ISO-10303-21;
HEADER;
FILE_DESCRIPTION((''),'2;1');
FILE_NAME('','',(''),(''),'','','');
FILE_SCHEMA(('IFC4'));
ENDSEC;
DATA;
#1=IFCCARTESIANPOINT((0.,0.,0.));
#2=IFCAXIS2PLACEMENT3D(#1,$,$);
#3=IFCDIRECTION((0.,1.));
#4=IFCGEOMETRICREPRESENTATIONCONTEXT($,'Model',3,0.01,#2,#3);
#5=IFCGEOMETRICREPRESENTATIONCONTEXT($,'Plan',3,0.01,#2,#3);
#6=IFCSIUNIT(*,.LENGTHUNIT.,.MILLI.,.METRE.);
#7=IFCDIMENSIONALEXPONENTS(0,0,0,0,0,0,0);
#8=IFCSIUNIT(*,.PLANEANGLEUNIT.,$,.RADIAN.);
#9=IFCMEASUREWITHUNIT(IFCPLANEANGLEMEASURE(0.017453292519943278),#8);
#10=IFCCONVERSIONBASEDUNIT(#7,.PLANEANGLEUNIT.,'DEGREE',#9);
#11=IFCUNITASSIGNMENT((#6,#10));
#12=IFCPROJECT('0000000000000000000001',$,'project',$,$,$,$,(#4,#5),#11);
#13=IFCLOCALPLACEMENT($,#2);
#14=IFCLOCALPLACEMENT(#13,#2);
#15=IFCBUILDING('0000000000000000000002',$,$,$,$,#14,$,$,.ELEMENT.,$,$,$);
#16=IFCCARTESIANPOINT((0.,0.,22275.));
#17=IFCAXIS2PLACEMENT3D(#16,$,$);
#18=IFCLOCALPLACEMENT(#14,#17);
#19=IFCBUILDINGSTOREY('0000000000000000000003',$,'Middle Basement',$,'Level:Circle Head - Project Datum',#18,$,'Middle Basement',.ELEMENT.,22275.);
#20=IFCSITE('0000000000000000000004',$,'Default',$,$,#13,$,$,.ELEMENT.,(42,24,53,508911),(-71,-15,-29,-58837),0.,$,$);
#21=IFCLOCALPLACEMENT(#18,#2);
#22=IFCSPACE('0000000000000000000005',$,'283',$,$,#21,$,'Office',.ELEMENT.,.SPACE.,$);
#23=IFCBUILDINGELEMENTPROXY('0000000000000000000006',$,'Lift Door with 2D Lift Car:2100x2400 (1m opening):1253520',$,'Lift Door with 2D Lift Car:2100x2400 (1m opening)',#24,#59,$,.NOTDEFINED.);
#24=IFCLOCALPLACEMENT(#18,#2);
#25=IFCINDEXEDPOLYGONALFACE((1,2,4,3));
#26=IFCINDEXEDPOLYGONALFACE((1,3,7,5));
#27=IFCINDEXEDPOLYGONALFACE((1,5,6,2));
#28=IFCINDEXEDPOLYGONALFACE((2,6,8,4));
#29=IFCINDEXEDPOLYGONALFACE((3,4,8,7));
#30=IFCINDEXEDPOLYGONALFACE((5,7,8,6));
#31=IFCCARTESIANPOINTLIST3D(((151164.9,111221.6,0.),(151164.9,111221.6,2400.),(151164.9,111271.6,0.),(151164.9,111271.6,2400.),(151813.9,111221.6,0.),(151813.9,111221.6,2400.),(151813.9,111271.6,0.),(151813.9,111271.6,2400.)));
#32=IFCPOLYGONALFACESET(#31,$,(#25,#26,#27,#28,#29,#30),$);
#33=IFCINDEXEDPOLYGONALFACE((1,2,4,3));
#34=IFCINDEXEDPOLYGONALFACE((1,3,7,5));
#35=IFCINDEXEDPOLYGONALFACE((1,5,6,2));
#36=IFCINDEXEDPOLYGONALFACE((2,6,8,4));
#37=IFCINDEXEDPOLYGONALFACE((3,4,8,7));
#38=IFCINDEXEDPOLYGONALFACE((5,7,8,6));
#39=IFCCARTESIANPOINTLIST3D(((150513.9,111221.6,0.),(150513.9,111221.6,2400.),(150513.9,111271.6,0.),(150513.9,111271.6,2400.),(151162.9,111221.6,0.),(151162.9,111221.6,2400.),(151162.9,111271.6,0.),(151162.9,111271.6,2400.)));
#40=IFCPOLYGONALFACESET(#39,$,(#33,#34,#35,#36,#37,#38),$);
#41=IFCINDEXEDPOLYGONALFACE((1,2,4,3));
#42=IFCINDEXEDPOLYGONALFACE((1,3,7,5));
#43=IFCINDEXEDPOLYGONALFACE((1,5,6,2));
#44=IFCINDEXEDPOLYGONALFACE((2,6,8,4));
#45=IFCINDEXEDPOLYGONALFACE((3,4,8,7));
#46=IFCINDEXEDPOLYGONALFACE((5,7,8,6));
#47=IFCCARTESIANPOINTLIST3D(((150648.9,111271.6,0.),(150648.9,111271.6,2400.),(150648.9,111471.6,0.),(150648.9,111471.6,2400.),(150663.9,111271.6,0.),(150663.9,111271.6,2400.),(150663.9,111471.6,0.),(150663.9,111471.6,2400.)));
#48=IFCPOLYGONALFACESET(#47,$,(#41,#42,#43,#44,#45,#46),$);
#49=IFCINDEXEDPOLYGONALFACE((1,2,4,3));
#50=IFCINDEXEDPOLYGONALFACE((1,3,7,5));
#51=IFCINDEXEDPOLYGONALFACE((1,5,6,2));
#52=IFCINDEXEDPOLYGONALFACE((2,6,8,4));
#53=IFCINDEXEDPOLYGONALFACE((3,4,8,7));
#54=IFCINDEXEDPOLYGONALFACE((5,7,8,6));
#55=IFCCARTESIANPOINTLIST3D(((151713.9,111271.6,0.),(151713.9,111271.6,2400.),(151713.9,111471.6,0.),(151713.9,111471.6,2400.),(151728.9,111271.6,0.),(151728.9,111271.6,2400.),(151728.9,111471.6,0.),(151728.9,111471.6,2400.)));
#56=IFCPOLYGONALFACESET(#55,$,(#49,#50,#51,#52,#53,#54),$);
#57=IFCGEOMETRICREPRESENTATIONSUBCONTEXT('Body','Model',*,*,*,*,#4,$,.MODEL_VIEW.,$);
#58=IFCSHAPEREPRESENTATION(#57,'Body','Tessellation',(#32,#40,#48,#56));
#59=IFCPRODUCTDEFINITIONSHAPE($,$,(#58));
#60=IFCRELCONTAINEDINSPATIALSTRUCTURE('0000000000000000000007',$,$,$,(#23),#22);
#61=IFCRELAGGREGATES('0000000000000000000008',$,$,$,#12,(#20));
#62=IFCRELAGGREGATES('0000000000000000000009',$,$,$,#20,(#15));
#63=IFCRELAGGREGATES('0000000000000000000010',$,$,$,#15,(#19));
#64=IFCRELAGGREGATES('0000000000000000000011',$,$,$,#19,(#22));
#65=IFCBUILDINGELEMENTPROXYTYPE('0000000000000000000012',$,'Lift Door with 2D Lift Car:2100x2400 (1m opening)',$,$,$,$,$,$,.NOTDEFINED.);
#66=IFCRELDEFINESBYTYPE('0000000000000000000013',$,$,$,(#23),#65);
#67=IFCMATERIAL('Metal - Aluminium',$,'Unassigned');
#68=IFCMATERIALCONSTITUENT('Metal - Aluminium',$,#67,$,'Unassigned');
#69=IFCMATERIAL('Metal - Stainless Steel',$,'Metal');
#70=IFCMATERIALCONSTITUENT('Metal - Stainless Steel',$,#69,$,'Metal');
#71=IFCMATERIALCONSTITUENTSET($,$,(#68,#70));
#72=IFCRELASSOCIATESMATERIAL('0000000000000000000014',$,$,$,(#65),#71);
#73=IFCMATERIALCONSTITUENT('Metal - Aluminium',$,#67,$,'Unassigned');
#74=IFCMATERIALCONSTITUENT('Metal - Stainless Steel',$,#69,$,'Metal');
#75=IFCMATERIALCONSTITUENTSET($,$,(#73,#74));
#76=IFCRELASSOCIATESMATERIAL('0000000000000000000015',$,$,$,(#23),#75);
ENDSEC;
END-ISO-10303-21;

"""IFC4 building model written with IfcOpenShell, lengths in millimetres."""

from ifc_helpers import new_model, entity, si_unit, converted_unit, direction, frame, origin, place, context, subcontext, project, spatial, indexed_curve, outline, extrude, source, transform, mapped, material, constituent, constituent_set, type_object, type_shapes, element, save


model = new_model("IFC4")

# Units and contexts
model_context = context("Model", 3, precision=0.01, world=origin(), true_north=direction((0.0, 1.0)))
plan_context = context("Plan", 3, precision=0.01, world=origin(), true_north=direction((0.0, 1.0)))
body_context = subcontext(model_context, "Body", "Model", "MODEL_VIEW")
ifc_project = project(units=[si_unit("LENGTHUNIT", "METRE", prefix="MILLI"), converted_unit("PLANEANGLEUNIT", "DEGREE", entity("IfcPlaneAngleMeasure", 0.017453292519943278), si_unit("PLANEANGLEUNIT", "RADIAN"), dimensions=[0, 0, 0, 0, 0, 0, 0])], contexts=[model_context, plan_context])

# Site, building, storey
site_placement = place(None, origin())
site = spatial("IfcSite", under=ifc_project, at=site_placement, Name="Default", CompositionType="ELEMENT", RefLatitude=(42, 24, 53, 508911), RefLongitude=(-71, -15, -29, -58837), RefElevation=0.0)
building_placement = place(site_placement, origin())
building = spatial("IfcBuilding", under=site, at=building_placement, CompositionType="ELEMENT")
storey_placement = place(building_placement, frame((0.0, 0.0, 22275.0)))
storey = spatial("IfcBuildingStorey", under=building, at=storey_placement, Name="Middle Basement", ObjectType="Level:Circle Head - Project Datum", LongName="Middle Basement", CompositionType="ELEMENT", Elevation=22275.0)

# Shared definitions
space_1_placement = place(storey_placement, origin())
space_1 = spatial("IfcSpace", under=storey, at=space_1_placement, Name="283", LongName="Office", CompositionType="ELEMENT", PredefinedType="SPACE")

# Building element proxy
ifc_material_1 = material(Name="Metal - Aluminium", Category="Unassigned")
ifc_material_2 = material(Name="Metal - Stainless Steel", Category="Metal")
ifc_constituent_1 = constituent(ifc_material_1, Name="Metal - Aluminium", Category="Unassigned")
ifc_constituent_2 = constituent(ifc_material_2, Name="Metal - Stainless Steel", Category="Metal")
ifc_constituent_set_1 = constituent_set(constituents=[ifc_constituent_1, ifc_constituent_2])
building_element_proxy_type_1 = type_object("IfcBuildingElementProxyType", Name="Lift Door with 2D Lift Car:2100x2400 (1m opening)", PredefinedType="NOTDEFINED", material=ifc_constituent_set_1)
shared_shape_1 = source(origin(), body_context, "Body", "SweptSolid", [
    extrude(outline(indexed_curve([(-324.5, -25.0), (324.5, -25.0), (324.5, 25.0), (-324.5, 25.0), (-324.5, -25.0)], self_intersect=False)), frame((-575.5, 125.0, 0.0), z_axis=(0.0, 0.0, 1.0), x_axis=(-1.0, 0.0, 0.0)), (0.0, 0.0, 1.0), 2400.0),
    extrude(outline(indexed_curve([(-324.5, -25.0), (324.5, -25.0), (324.5, 25.0), (-324.5, 25.0), (-324.5, -25.0)], self_intersect=False)), frame((75.5, 125.0, 0.0), z_axis=(0.0, 0.0, 1.0), x_axis=(-1.0, 0.0, 0.0)), (0.0, 0.0, 1.0), 2400.0),
    extrude(outline(indexed_curve([(-7.5, -100.0), (7.5, -100.0), (7.5, 100.0), (-7.5, 100.0), (-7.5, -100.0)], self_intersect=False)), frame((257.5, 0.0, 0.0), z_axis=(0.0, 0.0, 1.0), x_axis=(-1.0, 0.0, 0.0)), (0.0, 0.0, 1.0), 2400.0),
    extrude(outline(indexed_curve([(-100.0, -7.5), (100.0, -7.5), (100.0, 7.5), (-100.0, 7.5), (-100.0, -7.5)], self_intersect=False)), frame((-807.5, 0.0, 0.0), z_axis=(0.0, 0.0, 1.0), x_axis=(0.0, -1.0, 0.0)), (0.0, 0.0, 1.0), 2400.0),
])
type_shapes(building_element_proxy_type_1, [shared_shape_1])
ifc_constituent_3 = constituent(ifc_material_1, Name="Metal - Aluminium", Category="Unassigned")
ifc_constituent_4 = constituent(ifc_material_2, Name="Metal - Stainless Steel", Category="Metal")
ifc_constituent_set_2 = constituent_set(constituents=[ifc_constituent_3, ifc_constituent_4])
proxy_1_placement = place(space_1_placement, frame((150913.9, 111371.6, 0.0), z_axis=(0.0, 0.0, 1.0), x_axis=(-1.0, 0.0, 0.0)))
element("IfcBuildingElementProxy", 1, at=proxy_1_placement, inside=space_1, type_object=building_element_proxy_type_1, material=ifc_constituent_set_2, Name="Lift Door with 2D Lift Car:2100x2400 (1m opening):1253520", ObjectType="Lift Door with 2D Lift Car:2100x2400 (1m opening)", PredefinedType="NOTDEFINED", context=body_context, shape_type="MappedRepresentation", body=[
    mapped(shared_shape_1, transform((0.0, 0.0, 0.0), scale=1.0)),
])

save(model, "model.ifc")
